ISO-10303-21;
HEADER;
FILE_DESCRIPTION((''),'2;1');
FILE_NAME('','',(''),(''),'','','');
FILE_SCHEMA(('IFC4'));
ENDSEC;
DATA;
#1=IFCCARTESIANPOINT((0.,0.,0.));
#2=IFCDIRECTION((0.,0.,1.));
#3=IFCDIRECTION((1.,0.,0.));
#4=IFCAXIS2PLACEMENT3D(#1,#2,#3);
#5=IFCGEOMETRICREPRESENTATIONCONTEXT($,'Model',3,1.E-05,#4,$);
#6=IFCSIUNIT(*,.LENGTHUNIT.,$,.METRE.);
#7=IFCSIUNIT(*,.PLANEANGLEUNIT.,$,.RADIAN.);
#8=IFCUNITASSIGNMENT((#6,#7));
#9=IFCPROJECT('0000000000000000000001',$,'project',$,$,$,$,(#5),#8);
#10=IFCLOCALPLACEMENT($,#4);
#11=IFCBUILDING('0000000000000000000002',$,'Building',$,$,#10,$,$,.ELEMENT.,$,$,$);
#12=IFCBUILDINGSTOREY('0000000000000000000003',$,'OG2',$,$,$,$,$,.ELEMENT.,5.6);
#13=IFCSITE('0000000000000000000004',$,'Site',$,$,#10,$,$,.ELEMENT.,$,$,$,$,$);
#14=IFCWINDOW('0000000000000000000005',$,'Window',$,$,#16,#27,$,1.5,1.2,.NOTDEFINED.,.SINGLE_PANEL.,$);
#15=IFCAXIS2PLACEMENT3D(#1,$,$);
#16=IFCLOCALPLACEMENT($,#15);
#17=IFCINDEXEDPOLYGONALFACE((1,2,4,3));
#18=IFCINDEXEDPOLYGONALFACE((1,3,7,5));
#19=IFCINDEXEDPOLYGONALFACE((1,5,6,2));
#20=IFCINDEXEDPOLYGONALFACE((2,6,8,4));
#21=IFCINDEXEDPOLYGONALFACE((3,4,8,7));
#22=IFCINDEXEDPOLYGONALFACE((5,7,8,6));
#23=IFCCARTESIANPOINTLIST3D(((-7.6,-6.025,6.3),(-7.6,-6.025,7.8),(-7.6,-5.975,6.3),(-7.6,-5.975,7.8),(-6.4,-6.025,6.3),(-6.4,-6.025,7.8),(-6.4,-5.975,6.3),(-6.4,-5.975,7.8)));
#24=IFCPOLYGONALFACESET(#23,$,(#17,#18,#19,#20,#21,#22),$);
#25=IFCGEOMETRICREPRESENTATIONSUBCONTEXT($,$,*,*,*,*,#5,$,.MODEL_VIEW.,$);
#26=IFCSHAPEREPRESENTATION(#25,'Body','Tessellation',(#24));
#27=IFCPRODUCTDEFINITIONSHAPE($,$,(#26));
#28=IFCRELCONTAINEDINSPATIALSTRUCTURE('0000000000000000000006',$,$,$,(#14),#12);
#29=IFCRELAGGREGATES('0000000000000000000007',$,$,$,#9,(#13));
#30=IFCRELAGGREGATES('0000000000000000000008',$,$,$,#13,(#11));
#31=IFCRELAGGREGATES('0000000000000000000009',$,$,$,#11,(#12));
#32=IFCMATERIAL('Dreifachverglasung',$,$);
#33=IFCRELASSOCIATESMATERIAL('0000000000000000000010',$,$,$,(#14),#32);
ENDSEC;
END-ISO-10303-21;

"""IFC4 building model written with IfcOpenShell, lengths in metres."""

from ifc_helpers import new_model, si_unit, frame, origin, origin_with_axes, origin_2d, place, context, subcontext, project, spatial, rectangle, extrude, material, element, save


model = new_model("IFC4")

# Units and contexts
model_context = context("Model", 3, precision=1e-05, world=origin_with_axes())
sub_context = subcontext(model_context, None, None, "MODEL_VIEW")
ifc_project = project(units=[si_unit("LENGTHUNIT", "METRE"), si_unit("PLANEANGLEUNIT", "RADIAN")], contexts=[model_context])

# Site, building, storey
placement_1 = place(None, origin_with_axes())
site = spatial("IfcSite", under=ifc_project, at=placement_1, Name="Site", CompositionType="ELEMENT")
building = spatial("IfcBuilding", under=site, at=placement_1, Name="Building", CompositionType="ELEMENT")
storey = spatial("IfcBuildingStorey", under=building, Name="OG2", CompositionType="ELEMENT", Elevation=5.6)

# Window
ifc_material = material(Name="Dreifachverglasung")
placement_2 = place(None, origin_with_axes())
window_placement = place(placement_2, frame((-7.0, -6.0, 6.3)))
element("IfcWindow", 1, at=window_placement, inside=storey, material=ifc_material, Name="Window", OverallHeight=1.5, OverallWidth=1.2, PartitioningType="SINGLE_PANEL", PredefinedType="NOTDEFINED", context=sub_context, shape_type="SweptSolid", body=[
    extrude(rectangle(XDim=1.2, YDim=0.05, at=origin_2d()), origin(), (0.0, 0.0, 1.0), 1.5),
])

save(model, "model.ifc")
